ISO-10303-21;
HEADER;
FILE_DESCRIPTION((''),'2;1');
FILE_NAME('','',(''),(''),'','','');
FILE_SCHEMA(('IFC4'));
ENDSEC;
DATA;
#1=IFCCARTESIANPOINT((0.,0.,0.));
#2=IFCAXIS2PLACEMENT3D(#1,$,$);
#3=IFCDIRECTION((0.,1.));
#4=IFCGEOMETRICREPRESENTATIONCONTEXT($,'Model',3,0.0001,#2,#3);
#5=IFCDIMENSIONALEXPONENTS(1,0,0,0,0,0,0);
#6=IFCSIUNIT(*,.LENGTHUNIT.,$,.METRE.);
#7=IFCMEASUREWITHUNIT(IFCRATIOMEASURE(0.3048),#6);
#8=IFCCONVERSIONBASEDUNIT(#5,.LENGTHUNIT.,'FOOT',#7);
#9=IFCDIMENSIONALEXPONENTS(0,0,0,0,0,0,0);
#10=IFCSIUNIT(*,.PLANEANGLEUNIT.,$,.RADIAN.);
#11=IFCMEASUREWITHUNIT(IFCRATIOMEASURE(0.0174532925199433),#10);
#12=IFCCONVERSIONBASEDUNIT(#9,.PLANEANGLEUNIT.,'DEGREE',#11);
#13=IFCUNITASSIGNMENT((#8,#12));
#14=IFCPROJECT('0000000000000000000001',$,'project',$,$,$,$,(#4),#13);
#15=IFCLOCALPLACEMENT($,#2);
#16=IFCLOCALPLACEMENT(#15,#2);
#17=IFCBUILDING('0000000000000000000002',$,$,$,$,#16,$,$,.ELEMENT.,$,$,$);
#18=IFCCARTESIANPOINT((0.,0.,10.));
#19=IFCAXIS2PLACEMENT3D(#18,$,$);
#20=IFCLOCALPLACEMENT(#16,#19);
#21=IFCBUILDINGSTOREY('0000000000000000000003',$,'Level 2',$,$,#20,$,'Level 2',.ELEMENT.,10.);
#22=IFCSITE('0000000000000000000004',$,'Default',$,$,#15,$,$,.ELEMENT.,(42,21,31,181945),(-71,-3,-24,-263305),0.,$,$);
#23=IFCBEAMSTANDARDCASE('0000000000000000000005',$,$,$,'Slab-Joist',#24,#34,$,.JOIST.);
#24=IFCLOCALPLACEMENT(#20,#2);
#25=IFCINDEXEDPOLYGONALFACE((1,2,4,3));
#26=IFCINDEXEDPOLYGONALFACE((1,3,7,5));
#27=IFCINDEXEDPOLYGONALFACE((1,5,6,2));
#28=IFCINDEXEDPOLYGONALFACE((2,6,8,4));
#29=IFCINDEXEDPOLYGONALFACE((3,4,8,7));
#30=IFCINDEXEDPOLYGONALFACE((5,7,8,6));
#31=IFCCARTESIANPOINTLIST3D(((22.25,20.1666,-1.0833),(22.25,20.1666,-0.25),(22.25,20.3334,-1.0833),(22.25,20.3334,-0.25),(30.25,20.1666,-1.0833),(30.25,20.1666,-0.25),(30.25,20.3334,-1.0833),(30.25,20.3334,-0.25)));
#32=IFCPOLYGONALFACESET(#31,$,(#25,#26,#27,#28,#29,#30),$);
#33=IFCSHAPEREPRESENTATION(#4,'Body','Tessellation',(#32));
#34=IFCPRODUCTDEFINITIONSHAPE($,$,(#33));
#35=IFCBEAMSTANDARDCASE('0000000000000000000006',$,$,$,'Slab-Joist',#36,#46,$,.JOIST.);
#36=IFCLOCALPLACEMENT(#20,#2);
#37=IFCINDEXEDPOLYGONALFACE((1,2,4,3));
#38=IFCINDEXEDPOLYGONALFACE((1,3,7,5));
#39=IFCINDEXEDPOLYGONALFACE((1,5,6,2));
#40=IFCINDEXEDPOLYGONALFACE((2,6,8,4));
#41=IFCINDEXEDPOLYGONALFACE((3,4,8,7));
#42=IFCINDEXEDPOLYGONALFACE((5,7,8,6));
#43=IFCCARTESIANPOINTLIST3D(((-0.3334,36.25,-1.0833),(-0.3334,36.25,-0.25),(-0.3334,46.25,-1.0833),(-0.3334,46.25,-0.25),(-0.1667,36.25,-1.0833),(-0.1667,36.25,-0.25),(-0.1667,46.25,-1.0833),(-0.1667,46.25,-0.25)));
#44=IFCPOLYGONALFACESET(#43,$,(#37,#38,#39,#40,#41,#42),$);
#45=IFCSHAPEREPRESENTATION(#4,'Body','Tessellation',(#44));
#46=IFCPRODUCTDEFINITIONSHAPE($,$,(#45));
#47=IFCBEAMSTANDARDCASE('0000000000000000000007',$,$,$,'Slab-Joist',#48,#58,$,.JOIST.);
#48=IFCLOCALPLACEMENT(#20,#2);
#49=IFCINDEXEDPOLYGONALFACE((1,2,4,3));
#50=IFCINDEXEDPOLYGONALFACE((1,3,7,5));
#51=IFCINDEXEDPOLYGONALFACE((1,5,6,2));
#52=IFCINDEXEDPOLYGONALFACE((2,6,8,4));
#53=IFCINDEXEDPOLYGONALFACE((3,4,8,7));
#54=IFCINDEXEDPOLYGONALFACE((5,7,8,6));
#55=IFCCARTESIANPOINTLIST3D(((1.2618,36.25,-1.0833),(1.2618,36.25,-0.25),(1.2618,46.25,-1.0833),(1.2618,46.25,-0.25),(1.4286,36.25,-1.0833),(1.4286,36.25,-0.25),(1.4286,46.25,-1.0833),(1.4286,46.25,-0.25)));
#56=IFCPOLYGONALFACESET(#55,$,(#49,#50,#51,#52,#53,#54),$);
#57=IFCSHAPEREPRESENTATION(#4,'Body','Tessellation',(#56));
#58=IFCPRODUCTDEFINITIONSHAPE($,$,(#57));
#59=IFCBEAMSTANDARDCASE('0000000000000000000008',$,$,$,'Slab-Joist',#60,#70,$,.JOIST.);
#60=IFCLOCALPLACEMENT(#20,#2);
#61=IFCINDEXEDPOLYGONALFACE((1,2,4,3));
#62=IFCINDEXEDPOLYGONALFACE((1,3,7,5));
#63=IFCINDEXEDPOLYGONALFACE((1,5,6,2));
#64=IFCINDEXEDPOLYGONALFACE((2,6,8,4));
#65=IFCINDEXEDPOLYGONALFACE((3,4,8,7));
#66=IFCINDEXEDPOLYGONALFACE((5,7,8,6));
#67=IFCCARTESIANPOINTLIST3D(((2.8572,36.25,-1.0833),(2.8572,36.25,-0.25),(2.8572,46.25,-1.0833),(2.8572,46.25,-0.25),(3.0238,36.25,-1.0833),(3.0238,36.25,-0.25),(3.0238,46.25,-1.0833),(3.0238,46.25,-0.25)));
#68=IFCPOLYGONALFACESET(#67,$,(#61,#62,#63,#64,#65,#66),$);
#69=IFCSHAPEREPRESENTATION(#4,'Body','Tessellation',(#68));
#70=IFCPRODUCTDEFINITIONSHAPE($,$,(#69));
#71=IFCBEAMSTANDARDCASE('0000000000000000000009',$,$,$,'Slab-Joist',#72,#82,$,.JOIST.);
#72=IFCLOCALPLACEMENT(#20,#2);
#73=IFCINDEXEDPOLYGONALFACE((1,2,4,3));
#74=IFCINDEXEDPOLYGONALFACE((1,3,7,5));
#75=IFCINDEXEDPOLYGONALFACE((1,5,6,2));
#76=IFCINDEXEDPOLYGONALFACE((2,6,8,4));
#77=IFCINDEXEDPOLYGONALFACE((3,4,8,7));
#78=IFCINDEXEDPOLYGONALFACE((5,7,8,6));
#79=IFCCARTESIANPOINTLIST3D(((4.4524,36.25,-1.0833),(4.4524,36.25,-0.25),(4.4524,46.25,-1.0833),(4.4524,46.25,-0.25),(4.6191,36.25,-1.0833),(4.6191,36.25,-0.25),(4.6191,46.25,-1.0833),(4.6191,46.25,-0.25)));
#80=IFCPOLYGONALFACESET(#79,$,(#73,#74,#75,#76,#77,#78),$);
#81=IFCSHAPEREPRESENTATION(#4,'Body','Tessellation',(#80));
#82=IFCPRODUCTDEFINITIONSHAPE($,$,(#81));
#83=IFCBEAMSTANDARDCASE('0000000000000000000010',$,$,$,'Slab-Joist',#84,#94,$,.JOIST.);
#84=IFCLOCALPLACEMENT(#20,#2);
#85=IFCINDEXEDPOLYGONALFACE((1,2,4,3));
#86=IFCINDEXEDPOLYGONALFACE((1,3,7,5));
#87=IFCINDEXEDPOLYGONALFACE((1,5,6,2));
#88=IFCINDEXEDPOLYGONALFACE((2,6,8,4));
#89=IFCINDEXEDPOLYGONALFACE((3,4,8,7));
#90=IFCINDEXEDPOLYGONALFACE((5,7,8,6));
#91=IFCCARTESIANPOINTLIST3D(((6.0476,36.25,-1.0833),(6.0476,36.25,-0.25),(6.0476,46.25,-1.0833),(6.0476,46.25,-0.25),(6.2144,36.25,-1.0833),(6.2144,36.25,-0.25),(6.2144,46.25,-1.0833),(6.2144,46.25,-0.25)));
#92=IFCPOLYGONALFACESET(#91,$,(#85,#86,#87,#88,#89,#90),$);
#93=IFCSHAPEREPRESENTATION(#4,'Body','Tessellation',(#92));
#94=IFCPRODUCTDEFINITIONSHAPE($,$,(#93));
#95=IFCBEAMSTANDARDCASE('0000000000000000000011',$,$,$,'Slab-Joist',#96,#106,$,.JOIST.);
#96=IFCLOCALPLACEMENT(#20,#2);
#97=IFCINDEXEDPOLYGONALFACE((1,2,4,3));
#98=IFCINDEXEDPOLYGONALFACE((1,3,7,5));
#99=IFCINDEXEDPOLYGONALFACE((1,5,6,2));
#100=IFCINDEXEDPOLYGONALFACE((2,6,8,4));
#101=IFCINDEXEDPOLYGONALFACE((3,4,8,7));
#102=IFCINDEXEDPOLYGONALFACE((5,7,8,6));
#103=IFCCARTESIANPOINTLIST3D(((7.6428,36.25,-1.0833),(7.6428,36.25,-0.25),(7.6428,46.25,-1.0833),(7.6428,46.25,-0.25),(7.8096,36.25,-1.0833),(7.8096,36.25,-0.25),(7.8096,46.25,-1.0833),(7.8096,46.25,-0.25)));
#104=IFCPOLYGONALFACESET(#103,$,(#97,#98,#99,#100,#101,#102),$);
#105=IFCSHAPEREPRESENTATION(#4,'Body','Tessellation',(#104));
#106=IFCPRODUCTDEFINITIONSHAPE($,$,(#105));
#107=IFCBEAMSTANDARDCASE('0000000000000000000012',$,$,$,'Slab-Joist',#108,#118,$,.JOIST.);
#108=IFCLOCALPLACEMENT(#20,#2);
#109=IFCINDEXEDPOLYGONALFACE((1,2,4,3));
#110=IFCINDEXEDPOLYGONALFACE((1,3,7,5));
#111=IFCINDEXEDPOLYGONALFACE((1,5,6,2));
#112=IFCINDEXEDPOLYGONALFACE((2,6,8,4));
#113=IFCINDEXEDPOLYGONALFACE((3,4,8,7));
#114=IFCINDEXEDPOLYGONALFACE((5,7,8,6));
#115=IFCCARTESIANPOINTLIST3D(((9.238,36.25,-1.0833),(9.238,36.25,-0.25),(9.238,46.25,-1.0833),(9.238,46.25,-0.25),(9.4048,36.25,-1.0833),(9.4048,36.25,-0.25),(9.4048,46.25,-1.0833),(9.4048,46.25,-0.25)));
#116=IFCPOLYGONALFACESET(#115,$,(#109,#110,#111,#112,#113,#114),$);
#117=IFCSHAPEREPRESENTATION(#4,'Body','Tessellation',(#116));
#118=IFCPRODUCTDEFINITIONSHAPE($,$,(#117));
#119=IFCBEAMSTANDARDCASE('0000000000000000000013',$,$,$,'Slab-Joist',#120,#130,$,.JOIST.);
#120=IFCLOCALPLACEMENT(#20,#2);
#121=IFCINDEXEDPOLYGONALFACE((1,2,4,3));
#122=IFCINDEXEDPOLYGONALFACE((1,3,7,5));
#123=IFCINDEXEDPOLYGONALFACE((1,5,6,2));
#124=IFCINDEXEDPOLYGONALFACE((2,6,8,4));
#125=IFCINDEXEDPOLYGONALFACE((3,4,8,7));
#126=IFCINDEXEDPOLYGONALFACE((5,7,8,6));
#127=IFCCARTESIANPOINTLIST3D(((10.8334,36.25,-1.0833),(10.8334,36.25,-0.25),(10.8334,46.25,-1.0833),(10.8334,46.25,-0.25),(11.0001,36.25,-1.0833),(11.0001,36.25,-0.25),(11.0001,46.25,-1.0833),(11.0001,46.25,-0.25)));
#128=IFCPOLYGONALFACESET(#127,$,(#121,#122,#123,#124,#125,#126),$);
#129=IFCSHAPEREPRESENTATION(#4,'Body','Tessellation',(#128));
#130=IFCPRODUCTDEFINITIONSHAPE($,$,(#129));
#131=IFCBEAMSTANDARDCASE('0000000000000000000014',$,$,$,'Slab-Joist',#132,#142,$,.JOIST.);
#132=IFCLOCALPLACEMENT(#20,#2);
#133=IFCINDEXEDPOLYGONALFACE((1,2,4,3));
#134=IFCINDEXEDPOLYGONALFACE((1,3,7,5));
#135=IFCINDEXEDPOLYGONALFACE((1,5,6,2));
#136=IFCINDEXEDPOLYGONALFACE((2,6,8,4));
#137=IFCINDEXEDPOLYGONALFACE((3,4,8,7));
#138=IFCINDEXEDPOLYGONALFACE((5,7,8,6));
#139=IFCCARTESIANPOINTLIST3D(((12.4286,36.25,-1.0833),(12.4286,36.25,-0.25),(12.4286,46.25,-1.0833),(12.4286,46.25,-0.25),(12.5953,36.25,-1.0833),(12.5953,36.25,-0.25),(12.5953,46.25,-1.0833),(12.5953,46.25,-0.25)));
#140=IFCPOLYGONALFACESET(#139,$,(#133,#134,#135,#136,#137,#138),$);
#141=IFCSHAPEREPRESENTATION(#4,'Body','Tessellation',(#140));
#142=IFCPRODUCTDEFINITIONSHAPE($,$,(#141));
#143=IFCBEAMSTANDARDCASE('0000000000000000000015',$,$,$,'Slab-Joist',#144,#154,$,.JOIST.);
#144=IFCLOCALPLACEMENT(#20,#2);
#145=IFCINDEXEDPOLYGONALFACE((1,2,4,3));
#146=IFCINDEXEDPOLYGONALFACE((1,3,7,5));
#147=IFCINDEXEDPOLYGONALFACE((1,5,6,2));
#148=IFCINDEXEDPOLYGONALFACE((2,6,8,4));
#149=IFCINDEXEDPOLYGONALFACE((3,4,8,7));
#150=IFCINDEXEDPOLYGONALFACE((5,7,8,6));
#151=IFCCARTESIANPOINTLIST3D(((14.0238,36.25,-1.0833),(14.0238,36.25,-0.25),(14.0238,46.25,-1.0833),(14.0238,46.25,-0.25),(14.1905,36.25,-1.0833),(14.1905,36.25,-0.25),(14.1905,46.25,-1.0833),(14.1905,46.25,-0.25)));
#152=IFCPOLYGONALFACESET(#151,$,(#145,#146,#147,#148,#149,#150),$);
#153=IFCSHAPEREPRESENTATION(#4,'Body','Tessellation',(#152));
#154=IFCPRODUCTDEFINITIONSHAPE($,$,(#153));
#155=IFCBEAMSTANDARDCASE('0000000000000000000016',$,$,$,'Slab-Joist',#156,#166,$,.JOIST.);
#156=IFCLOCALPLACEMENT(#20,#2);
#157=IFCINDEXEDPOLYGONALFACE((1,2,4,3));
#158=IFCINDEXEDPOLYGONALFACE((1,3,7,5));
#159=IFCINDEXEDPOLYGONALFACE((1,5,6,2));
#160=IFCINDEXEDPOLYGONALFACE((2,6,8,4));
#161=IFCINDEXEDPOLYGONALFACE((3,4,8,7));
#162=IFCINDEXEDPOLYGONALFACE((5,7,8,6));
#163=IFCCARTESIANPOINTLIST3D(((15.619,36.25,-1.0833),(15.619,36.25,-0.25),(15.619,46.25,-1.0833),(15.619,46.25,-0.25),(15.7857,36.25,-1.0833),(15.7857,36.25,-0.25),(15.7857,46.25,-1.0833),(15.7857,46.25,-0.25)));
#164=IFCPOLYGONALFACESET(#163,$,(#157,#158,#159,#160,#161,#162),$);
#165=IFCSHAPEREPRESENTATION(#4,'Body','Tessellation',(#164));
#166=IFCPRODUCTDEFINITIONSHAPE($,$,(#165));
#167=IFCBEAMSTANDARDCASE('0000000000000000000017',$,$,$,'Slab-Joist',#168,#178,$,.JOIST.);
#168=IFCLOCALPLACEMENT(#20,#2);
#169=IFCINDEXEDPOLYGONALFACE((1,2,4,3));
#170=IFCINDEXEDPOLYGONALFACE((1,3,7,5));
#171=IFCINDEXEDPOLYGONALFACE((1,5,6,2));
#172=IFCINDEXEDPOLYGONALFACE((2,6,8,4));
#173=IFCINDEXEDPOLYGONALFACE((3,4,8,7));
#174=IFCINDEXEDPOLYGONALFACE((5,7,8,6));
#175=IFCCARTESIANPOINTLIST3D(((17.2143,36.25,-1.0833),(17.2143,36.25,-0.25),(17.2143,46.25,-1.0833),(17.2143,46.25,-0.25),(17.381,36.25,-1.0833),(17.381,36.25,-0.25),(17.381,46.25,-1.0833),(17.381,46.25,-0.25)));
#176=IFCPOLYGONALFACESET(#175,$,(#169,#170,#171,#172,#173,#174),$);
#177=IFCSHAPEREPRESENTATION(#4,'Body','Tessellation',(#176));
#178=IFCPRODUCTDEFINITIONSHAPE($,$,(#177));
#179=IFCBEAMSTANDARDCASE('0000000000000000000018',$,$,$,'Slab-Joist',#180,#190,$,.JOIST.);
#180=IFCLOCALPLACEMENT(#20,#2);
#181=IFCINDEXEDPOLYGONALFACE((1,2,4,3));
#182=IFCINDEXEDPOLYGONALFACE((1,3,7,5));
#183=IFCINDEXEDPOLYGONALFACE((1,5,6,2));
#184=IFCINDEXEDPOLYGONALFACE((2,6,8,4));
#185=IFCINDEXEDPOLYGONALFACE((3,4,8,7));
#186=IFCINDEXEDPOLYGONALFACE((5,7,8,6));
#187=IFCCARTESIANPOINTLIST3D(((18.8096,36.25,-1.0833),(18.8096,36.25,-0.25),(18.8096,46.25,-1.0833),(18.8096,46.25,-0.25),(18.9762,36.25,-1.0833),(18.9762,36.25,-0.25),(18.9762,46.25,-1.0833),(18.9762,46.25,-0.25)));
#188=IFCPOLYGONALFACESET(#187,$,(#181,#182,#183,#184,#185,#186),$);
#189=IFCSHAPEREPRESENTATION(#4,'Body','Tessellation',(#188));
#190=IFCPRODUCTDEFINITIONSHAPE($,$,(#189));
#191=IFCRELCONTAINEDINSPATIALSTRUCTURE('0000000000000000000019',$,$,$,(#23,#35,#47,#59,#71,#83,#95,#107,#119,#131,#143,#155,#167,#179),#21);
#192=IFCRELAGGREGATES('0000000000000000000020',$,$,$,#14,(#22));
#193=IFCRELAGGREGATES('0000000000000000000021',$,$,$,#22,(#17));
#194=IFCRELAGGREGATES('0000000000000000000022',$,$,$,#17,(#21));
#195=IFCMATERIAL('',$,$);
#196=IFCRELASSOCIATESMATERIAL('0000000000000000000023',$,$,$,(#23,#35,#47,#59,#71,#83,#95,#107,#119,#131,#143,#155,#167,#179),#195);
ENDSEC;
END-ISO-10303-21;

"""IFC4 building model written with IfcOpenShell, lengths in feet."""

from ifc_helpers import new_model, entity, si_unit, converted_unit, direction, frame, origin, origin_with_axes, place, context, project, spatial, rectangle, extrude, material, element, save


model = new_model("IFC4")

# Units and contexts
model_context = context("Model", 3, precision=0.0001, world=origin(), true_north=direction((0.0, 1.0)))
ifc_project = project(units=[converted_unit("LENGTHUNIT", "FOOT", entity("IfcRatioMeasure", 0.3048), si_unit("LENGTHUNIT", "METRE"), dimensions=[1, 0, 0, 0, 0, 0, 0]), converted_unit("PLANEANGLEUNIT", "DEGREE", entity("IfcRatioMeasure", 0.0174532925199433), si_unit("PLANEANGLEUNIT", "RADIAN"), dimensions=[0, 0, 0, 0, 0, 0, 0])], contexts=[model_context])

# Site, building, storey
site_placement = place(None, origin())
site = spatial("IfcSite", under=ifc_project, at=site_placement, Name="Default", CompositionType="ELEMENT", RefLatitude=(42, 21, 31, 181945), RefLongitude=(-71, -3, -24, -263305), RefElevation=0.0)
building_placement = place(site_placement, origin())
building = spatial("IfcBuilding", under=site, at=building_placement, CompositionType="ELEMENT")
storey_placement = place(building_placement, frame((0.0, 0.0, 10.0)))
storey = spatial("IfcBuildingStorey", under=building, at=storey_placement, Name="Level 2", LongName="Level 2", CompositionType="ELEMENT", Elevation=10.0)

# Beams
ifc_material = material(Name="")
placement_1 = place(storey_placement, frame((22.25, 20.25, 0.0), z_axis=(0.0, 0.0, 1.0), x_axis=(1.0, 0.0, 0.0)))
beam_1_placement = place(placement_1, frame((0.0, 0.0, -0.6667), z_axis=(1.0, 0.0, 0.0), x_axis=(0.0, 1.0, 0.0)))
element("IfcBeamStandardCase", 1, at=beam_1_placement, inside=storey, material=ifc_material, ObjectType="Slab-Joist", PredefinedType="JOIST", context=model_context, shape_type="SweptSolid", body=[
    extrude(rectangle(XDim=0.1667, YDim=0.8333), origin_with_axes(), (0.0, 0.0, 1.0), 8.0),
])
placement_2 = place(storey_placement, frame((-0.25, 36.25, 0.0), z_axis=(0.0, 0.0, 1.0), x_axis=(1.0, 0.0, 0.0)))
beam_2_placement = place(placement_2, frame((0.0, 0.0, -0.6667), z_axis=(0.0, 1.0, 0.0), x_axis=(-1.0, 0.0, 0.0)))
element("IfcBeamStandardCase", 2, at=beam_2_placement, inside=storey, material=ifc_material, ObjectType="Slab-Joist", PredefinedType="JOIST", context=model_context, shape_type="SweptSolid", body=[
    extrude(rectangle(XDim=0.1667, YDim=0.8333), origin_with_axes(), (0.0, 0.0, 1.0), 10.0),
])
placement_3 = place(storey_placement, frame((-0.25, 36.25, 0.0), z_axis=(0.0, 0.0, 1.0), x_axis=(1.0, 0.0, 0.0)))
beam_3_placement = place(placement_3, frame((1.5952, 0.0, -0.6667), z_axis=(0.0, 1.0, 0.0), x_axis=(-1.0, 0.0, 0.0)))
element("IfcBeamStandardCase", 3, at=beam_3_placement, inside=storey, material=ifc_material, ObjectType="Slab-Joist", PredefinedType="JOIST", context=model_context, shape_type="SweptSolid", body=[
    extrude(rectangle(XDim=0.1667, YDim=0.8333), origin_with_axes(), (0.0, 0.0, 1.0), 10.0),
])
placement_4 = place(storey_placement, frame((-0.25, 36.25, 0.0), z_axis=(0.0, 0.0, 1.0), x_axis=(1.0, 0.0, 0.0)))
beam_4_placement = place(placement_4, frame((3.1905, 0.0, -0.6667), z_axis=(0.0, 1.0, 0.0), x_axis=(-1.0, 0.0, 0.0)))
element("IfcBeamStandardCase", 4, at=beam_4_placement, inside=storey, material=ifc_material, ObjectType="Slab-Joist", PredefinedType="JOIST", context=model_context, shape_type="SweptSolid", body=[
    extrude(rectangle(XDim=0.1667, YDim=0.8333), origin_with_axes(), (0.0, 0.0, 1.0), 10.0),
])
placement_5 = place(storey_placement, frame((-0.25, 36.25, 0.0), z_axis=(0.0, 0.0, 1.0), x_axis=(1.0, 0.0, 0.0)))
beam_5_placement = place(placement_5, frame((4.7857, 0.0, -0.6667), z_axis=(0.0, 1.0, 0.0), x_axis=(-1.0, 0.0, 0.0)))
element("IfcBeamStandardCase", 5, at=beam_5_placement, inside=storey, material=ifc_material, ObjectType="Slab-Joist", PredefinedType="JOIST", context=model_context, shape_type="SweptSolid", body=[
    extrude(rectangle(XDim=0.1667, YDim=0.8333), origin_with_axes(), (0.0, 0.0, 1.0), 10.0),
])
placement_6 = place(storey_placement, frame((-0.25, 36.25, 0.0), z_axis=(0.0, 0.0, 1.0), x_axis=(1.0, 0.0, 0.0)))
beam_6_placement = place(placement_6, frame((6.381, 0.0, -0.6667), z_axis=(0.0, 1.0, 0.0), x_axis=(-1.0, 0.0, 0.0)))
element("IfcBeamStandardCase", 6, at=beam_6_placement, inside=storey, material=ifc_material, ObjectType="Slab-Joist", PredefinedType="JOIST", context=model_context, shape_type="SweptSolid", body=[
    extrude(rectangle(XDim=0.1667, YDim=0.8333), origin_with_axes(), (0.0, 0.0, 1.0), 10.0),
])
placement_7 = place(storey_placement, frame((-0.25, 36.25, 0.0), z_axis=(0.0, 0.0, 1.0), x_axis=(1.0, 0.0, 0.0)))
beam_7_placement = place(placement_7, frame((7.9762, 0.0, -0.6667), z_axis=(0.0, 1.0, 0.0), x_axis=(-1.0, 0.0, 0.0)))
element("IfcBeamStandardCase", 7, at=beam_7_placement, inside=storey, material=ifc_material, ObjectType="Slab-Joist", PredefinedType="JOIST", context=model_context, shape_type="SweptSolid", body=[
    extrude(rectangle(XDim=0.1667, YDim=0.8333), origin_with_axes(), (0.0, 0.0, 1.0), 10.0),
])
placement_8 = place(storey_placement, frame((-0.25, 36.25, 0.0), z_axis=(0.0, 0.0, 1.0), x_axis=(1.0, 0.0, 0.0)))
beam_8_placement = place(placement_8, frame((9.5714, 0.0, -0.6667), z_axis=(0.0, 1.0, 0.0), x_axis=(-1.0, 0.0, 0.0)))
element("IfcBeamStandardCase", 8, at=beam_8_placement, inside=storey, material=ifc_material, ObjectType="Slab-Joist", PredefinedType="JOIST", context=model_context, shape_type="SweptSolid", body=[
    extrude(rectangle(XDim=0.1667, YDim=0.8333), origin_with_axes(), (0.0, 0.0, 1.0), 10.0),
])
placement_9 = place(storey_placement, frame((-0.25, 36.25, 0.0), z_axis=(0.0, 0.0, 1.0), x_axis=(1.0, 0.0, 0.0)))
beam_9_placement = place(placement_9, frame((11.1667, 0.0, -0.6667), z_axis=(0.0, 1.0, 0.0), x_axis=(-1.0, 0.0, 0.0)))
element("IfcBeamStandardCase", 9, at=beam_9_placement, inside=storey, material=ifc_material, ObjectType="Slab-Joist", PredefinedType="JOIST", context=model_context, shape_type="SweptSolid", body=[
    extrude(rectangle(XDim=0.1667, YDim=0.8333), origin_with_axes(), (0.0, 0.0, 1.0), 10.0),
])
placement_10 = place(storey_placement, frame((-0.25, 36.25, 0.0), z_axis=(0.0, 0.0, 1.0), x_axis=(1.0, 0.0, 0.0)))
beam_10_placement = place(placement_10, frame((12.7619, 0.0, -0.6667), z_axis=(0.0, 1.0, 0.0), x_axis=(-1.0, 0.0, 0.0)))
element("IfcBeamStandardCase", 10, at=beam_10_placement, inside=storey, material=ifc_material, ObjectType="Slab-Joist", PredefinedType="JOIST", context=model_context, shape_type="SweptSolid", body=[
    extrude(rectangle(XDim=0.1667, YDim=0.8333), origin_with_axes(), (0.0, 0.0, 1.0), 10.0),
])
placement_11 = place(storey_placement, frame((-0.25, 36.25, 0.0), z_axis=(0.0, 0.0, 1.0), x_axis=(1.0, 0.0, 0.0)))
beam_11_placement = place(placement_11, frame((14.3572, 0.0, -0.6667), z_axis=(0.0, 1.0, 0.0), x_axis=(-1.0, 0.0, 0.0)))
element("IfcBeamStandardCase", 11, at=beam_11_placement, inside=storey, material=ifc_material, ObjectType="Slab-Joist", PredefinedType="JOIST", context=model_context, shape_type="SweptSolid", body=[
    extrude(rectangle(XDim=0.1667, YDim=0.8333), origin_with_axes(), (0.0, 0.0, 1.0), 10.0),
])
placement_12 = place(storey_placement, frame((-0.25, 36.25, 0.0), z_axis=(0.0, 0.0, 1.0), x_axis=(1.0, 0.0, 0.0)))
beam_12_placement = place(placement_12, frame((15.9524, 0.0, -0.6667), z_axis=(0.0, 1.0, 0.0), x_axis=(-1.0, 0.0, 0.0)))
element("IfcBeamStandardCase", 12, at=beam_12_placement, inside=storey, material=ifc_material, ObjectType="Slab-Joist", PredefinedType="JOIST", context=model_context, shape_type="SweptSolid", body=[
    extrude(rectangle(XDim=0.1667, YDim=0.8333), origin_with_axes(), (0.0, 0.0, 1.0), 10.0),
])
placement_13 = place(storey_placement, frame((-0.25, 36.25, 0.0), z_axis=(0.0, 0.0, 1.0), x_axis=(1.0, 0.0, 0.0)))
beam_13_placement = place(placement_13, frame((17.5476, 0.0, -0.6667), z_axis=(0.0, 1.0, 0.0), x_axis=(-1.0, 0.0, 0.0)))
element("IfcBeamStandardCase", 13, at=beam_13_placement, inside=storey, material=ifc_material, ObjectType="Slab-Joist", PredefinedType="JOIST", context=model_context, shape_type="SweptSolid", body=[
    extrude(rectangle(XDim=0.1667, YDim=0.8333), origin_with_axes(), (0.0, 0.0, 1.0), 10.0),
])
placement_14 = place(storey_placement, frame((-0.25, 36.25, 0.0), z_axis=(0.0, 0.0, 1.0), x_axis=(1.0, 0.0, 0.0)))
beam_14_placement = place(placement_14, frame((19.1429, 0.0, -0.6667), z_axis=(0.0, 1.0, 0.0), x_axis=(-1.0, 0.0, 0.0)))
element("IfcBeamStandardCase", 14, at=beam_14_placement, inside=storey, material=ifc_material, ObjectType="Slab-Joist", PredefinedType="JOIST", context=model_context, shape_type="SweptSolid", body=[
    extrude(rectangle(XDim=0.1667, YDim=0.8333), origin_with_axes(), (0.0, 0.0, 1.0), 10.0),
])

save(model, "model.ifc")
